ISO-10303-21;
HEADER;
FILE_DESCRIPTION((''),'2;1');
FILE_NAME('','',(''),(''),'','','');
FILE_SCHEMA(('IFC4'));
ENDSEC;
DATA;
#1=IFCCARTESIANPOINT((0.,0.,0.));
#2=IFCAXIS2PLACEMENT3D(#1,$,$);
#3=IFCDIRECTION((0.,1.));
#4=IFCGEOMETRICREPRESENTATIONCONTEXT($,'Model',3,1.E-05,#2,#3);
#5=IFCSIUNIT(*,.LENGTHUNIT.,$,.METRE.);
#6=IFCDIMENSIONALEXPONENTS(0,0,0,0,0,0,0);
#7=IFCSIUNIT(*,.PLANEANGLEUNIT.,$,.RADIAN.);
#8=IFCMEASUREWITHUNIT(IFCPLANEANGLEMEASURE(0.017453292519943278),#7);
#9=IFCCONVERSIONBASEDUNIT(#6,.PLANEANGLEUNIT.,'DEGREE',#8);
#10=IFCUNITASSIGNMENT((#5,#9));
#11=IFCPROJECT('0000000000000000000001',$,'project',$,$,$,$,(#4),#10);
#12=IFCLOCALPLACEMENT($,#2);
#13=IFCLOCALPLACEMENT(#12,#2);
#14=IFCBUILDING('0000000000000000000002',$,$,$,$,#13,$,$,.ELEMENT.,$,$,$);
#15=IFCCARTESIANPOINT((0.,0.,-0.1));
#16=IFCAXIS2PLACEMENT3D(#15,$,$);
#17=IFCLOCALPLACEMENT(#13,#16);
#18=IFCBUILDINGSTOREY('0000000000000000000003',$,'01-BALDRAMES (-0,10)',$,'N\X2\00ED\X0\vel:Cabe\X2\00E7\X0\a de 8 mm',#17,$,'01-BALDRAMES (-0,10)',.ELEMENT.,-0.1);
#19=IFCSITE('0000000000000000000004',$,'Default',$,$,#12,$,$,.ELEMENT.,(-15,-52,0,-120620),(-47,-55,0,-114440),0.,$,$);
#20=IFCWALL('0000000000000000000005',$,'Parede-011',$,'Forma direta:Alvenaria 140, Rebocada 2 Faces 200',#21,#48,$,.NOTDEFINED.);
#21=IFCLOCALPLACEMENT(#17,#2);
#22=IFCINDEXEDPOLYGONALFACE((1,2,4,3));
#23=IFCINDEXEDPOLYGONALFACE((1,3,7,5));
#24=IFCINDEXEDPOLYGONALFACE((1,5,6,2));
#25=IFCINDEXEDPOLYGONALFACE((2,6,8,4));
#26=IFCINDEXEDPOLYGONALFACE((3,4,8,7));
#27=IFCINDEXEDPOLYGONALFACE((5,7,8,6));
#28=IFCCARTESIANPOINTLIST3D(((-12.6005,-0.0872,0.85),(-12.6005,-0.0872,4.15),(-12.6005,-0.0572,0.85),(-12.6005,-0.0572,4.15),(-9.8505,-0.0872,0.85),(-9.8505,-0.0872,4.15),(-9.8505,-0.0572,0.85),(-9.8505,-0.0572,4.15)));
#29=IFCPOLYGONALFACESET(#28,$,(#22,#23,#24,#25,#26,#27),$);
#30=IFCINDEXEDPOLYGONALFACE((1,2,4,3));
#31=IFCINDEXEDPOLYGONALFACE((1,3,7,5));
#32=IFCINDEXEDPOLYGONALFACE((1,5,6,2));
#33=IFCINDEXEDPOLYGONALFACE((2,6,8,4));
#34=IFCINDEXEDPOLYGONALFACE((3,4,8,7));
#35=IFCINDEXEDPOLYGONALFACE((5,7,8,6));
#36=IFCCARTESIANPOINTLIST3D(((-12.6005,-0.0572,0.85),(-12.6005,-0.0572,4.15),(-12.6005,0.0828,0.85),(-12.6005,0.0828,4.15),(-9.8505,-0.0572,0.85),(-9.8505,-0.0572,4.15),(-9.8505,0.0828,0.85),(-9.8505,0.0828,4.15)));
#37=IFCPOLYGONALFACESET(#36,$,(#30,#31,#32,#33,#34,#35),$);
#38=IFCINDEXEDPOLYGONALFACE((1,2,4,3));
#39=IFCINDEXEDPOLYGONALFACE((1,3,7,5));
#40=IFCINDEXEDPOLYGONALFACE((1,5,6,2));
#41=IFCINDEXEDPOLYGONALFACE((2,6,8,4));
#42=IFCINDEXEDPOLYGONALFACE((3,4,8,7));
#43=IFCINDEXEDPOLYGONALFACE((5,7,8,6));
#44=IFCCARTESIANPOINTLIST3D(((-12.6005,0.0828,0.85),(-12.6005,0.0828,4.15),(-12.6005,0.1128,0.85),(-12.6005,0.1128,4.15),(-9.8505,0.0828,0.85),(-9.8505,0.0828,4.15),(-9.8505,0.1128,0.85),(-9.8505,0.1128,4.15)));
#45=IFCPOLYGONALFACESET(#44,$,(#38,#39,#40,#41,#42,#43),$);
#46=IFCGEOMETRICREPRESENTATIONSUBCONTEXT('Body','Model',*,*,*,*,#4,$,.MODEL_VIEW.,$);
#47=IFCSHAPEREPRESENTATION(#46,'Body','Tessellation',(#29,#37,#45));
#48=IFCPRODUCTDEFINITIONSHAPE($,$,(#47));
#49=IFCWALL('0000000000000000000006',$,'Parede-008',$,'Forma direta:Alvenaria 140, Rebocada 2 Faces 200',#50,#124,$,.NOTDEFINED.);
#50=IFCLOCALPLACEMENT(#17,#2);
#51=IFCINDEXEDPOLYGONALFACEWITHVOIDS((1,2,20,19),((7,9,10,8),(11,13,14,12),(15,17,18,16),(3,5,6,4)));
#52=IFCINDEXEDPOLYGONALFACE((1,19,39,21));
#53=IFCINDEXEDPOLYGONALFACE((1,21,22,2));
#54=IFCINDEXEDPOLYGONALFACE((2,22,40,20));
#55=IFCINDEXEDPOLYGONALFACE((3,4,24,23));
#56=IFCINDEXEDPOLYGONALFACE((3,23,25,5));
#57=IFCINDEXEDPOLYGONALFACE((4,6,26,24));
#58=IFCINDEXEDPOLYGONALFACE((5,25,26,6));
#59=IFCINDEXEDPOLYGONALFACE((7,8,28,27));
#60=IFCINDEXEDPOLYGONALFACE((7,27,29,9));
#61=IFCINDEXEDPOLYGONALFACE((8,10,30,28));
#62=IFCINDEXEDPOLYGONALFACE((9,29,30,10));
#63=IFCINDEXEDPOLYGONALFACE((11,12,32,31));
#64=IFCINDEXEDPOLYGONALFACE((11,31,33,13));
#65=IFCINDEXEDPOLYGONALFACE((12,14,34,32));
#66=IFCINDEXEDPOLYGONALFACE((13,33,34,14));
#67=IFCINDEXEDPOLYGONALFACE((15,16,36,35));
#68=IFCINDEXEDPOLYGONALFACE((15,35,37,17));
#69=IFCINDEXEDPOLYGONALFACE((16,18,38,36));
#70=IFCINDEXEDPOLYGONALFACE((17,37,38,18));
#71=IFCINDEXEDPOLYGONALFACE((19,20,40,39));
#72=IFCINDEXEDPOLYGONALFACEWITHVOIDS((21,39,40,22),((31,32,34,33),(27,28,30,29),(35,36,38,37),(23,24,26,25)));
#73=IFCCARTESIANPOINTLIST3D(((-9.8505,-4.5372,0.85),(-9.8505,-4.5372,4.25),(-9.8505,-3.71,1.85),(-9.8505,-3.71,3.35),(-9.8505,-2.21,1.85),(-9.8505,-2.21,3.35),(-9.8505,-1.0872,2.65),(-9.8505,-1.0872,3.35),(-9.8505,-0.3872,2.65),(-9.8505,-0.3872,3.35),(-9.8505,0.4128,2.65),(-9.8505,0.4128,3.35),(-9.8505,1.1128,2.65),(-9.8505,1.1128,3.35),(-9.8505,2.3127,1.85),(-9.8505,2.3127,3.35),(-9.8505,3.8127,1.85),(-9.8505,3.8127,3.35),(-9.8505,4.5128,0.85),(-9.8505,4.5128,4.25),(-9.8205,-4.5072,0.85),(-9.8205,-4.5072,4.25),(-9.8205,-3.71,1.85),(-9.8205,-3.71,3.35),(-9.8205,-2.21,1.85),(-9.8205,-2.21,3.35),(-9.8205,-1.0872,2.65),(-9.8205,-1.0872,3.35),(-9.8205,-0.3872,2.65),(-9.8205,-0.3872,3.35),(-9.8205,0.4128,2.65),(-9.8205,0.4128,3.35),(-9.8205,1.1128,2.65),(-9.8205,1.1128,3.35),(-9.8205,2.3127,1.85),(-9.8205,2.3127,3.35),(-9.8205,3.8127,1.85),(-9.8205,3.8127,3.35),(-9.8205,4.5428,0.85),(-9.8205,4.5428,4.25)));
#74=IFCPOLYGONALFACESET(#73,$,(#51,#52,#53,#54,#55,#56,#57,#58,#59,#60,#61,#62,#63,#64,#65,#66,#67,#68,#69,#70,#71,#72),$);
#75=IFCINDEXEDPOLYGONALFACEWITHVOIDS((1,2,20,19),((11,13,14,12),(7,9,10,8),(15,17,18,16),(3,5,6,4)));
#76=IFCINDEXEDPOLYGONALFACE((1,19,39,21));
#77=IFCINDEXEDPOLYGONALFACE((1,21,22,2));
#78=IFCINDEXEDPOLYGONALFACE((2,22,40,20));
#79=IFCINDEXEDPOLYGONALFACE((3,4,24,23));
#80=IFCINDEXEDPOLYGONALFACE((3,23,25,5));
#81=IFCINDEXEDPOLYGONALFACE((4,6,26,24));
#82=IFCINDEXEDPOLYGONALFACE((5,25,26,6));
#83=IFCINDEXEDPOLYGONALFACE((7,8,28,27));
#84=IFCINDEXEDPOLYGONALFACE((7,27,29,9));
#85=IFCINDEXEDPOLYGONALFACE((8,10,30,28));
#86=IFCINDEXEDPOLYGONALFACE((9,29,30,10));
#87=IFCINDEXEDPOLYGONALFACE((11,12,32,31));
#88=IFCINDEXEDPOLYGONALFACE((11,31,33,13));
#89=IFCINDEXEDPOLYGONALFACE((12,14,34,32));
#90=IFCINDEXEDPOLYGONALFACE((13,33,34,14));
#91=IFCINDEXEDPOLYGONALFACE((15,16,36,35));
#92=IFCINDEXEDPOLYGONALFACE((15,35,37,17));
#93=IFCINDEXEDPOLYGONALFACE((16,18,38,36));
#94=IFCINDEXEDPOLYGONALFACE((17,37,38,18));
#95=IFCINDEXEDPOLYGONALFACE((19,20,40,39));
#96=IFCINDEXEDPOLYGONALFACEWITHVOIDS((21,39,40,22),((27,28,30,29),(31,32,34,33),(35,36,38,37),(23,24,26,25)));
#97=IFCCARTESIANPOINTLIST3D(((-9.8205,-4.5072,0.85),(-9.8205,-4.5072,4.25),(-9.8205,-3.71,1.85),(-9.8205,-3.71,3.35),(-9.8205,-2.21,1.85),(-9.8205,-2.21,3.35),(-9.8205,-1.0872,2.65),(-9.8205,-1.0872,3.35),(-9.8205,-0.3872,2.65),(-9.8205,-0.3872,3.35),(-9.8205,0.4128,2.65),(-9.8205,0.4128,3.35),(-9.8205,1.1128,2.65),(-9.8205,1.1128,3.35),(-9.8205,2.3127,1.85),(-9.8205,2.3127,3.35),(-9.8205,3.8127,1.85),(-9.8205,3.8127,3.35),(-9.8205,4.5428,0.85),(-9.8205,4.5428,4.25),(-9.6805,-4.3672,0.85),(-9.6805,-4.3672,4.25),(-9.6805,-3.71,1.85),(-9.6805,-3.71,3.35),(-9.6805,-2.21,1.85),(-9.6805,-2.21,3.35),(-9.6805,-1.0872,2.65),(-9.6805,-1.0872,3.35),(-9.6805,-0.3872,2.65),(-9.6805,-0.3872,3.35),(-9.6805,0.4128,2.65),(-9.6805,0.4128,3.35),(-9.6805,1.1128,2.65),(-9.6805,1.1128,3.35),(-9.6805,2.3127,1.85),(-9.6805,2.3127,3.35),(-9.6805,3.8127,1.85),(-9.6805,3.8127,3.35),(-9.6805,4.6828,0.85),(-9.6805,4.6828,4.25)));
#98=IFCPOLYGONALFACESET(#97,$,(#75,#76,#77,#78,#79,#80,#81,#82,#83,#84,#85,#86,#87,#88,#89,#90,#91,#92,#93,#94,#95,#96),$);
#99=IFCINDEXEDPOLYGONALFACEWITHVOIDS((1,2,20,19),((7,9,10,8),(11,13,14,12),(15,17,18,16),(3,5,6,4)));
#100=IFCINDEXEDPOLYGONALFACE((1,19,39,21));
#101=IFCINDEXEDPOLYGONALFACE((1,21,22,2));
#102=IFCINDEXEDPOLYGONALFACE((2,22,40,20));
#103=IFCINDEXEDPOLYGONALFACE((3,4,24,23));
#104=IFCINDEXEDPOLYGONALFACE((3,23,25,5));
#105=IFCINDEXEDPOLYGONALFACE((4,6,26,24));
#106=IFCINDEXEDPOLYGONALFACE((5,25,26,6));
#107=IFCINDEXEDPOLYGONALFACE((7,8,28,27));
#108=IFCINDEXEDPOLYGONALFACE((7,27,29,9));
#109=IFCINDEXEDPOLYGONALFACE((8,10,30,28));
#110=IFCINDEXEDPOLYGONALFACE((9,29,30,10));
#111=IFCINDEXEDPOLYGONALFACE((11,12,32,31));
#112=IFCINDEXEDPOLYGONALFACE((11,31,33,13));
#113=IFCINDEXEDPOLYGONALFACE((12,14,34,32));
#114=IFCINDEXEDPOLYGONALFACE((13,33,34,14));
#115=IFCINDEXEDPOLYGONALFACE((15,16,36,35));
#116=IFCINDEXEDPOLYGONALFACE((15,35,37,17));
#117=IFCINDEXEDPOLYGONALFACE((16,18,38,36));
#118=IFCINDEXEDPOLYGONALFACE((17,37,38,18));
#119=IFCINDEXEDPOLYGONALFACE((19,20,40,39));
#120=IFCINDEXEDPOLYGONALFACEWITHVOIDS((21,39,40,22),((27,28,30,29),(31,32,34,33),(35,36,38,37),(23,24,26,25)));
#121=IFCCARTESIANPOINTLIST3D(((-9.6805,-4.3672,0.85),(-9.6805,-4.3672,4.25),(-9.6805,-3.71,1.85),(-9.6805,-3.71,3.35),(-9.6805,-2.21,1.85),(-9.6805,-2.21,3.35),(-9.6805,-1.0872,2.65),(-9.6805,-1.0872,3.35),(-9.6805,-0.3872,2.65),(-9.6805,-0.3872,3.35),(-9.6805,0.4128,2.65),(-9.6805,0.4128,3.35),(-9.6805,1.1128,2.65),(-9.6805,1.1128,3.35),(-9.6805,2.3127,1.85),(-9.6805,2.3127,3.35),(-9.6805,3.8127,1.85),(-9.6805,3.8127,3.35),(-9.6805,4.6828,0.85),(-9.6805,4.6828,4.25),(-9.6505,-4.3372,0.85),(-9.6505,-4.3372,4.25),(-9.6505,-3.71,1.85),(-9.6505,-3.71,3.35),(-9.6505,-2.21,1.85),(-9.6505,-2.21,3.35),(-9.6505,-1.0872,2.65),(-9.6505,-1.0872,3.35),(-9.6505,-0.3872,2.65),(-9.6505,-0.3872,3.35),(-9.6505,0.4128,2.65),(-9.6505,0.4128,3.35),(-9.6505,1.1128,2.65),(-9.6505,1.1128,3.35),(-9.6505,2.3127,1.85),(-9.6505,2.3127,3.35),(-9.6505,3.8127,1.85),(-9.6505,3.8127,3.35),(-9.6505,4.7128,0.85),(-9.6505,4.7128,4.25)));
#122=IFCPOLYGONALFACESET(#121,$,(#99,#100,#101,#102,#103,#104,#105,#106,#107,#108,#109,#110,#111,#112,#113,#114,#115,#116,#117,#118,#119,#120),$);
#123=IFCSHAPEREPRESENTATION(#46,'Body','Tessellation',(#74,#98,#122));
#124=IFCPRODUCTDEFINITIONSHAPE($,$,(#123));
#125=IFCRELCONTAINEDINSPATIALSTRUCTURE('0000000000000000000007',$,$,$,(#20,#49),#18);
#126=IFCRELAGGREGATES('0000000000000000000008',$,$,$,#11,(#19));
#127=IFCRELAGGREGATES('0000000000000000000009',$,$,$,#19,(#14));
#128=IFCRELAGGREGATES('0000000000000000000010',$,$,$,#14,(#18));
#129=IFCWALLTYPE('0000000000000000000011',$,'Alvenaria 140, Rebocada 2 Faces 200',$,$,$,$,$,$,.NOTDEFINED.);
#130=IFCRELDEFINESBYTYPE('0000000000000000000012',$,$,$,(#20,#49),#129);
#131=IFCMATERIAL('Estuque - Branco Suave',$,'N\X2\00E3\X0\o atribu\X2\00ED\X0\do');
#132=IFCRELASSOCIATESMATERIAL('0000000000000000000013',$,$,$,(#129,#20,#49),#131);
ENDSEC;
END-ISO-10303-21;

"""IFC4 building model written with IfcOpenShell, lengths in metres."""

from ifc_helpers import new_model, entity, si_unit, converted_unit, direction, frame, origin, place, context, subcontext, project, spatial, indexed_curve, outline, extrude, material, type_object, element, save


model = new_model("IFC4")

# Units and contexts
model_context = context("Model", 3, precision=1e-05, world=origin(), true_north=direction((0.0, 1.0)))
body_context = subcontext(model_context, "Body", "Model", "MODEL_VIEW")
ifc_project = project(units=[si_unit("LENGTHUNIT", "METRE"), converted_unit("PLANEANGLEUNIT", "DEGREE", entity("IfcPlaneAngleMeasure", 0.017453292519943278), si_unit("PLANEANGLEUNIT", "RADIAN"), dimensions=[0, 0, 0, 0, 0, 0, 0])], contexts=[model_context])

# Site, building, storey
site_placement = place(None, origin())
site = spatial("IfcSite", under=ifc_project, at=site_placement, Name="Default", CompositionType="ELEMENT", RefLatitude=(-15, -52, 0, -120620), RefLongitude=(-47, -55, 0, -114440), RefElevation=0.0)
building_placement = place(site_placement, origin())
building = spatial("IfcBuilding", under=site, at=building_placement, CompositionType="ELEMENT")
storey_placement = place(building_placement, frame((0.0, 0.0, -0.1)))
storey = spatial("IfcBuildingStorey", under=building, at=storey_placement, Name="01-BALDRAMES (-0,10)", ObjectType="Nível:Cabeça de 8 mm", LongName="01-BALDRAMES (-0,10)", CompositionType="ELEMENT", Elevation=-0.1)

# Wall
ifc_material_1 = material(Name="Estuque - Branco Suave", Category="Não atribuído")
wall_type_1 = type_object("IfcWallType", Name="Alvenaria 140, Rebocada 2 Faces 200", PredefinedType="NOTDEFINED", material=ifc_material_1)
wall_1_placement = place(storey_placement, frame((-12.8005, -0.0872, 0.85)))
element("IfcWall", 1, at=wall_1_placement, inside=storey, type_object=wall_type_1, material=ifc_material_1, Name="Parede-011", ObjectType="Forma direta:Alvenaria 140, Rebocada 2 Faces 200", PredefinedType="NOTDEFINED", context=body_context, shape_type="SweptSolid", body=[
    extrude(outline(indexed_curve([(-0.015, -1.375), (0.015, -1.375), (0.015, 1.375), (-0.015, 1.375), (-0.015, -1.375)], self_intersect=False)), frame((1.575, 0.015, 0.0), z_axis=(0.0, 0.0, 1.0), x_axis=(-0.000011, -1.0, 0.0)), (0.0, 0.0, 1.0), 3.3),
    extrude(outline(indexed_curve([(-0.07, -1.375), (0.07, -1.375), (0.07, 1.375), (-0.07, 1.375), (-0.07, -1.375)], self_intersect=False)), frame((1.575, 0.1, 0.0), z_axis=(0.0, 0.0, 1.0), x_axis=(-0.000007, 1.0, 0.0)), (0.0, 0.0, 1.0), 3.3),
    extrude(outline(indexed_curve([(-0.015, -1.375), (0.015, -1.375), (0.015, 1.375), (-0.015, 1.375), (-0.015, -1.375)], self_intersect=False)), frame((1.575, 0.185, 0.0), z_axis=(0.0, 0.0, 1.0), x_axis=(-0.000007, 1.0, 0.0)), (0.0, 0.0, 1.0), 3.3),
])

# Wall, openings
wall_2_placement = place(storey_placement, frame((-9.8505, -4.5372, 0.85), z_axis=(0.0, 0.0, 1.0), x_axis=(0.0, 1.0, 0.0)))
wall_2 = element("IfcWall", 2, at=wall_2_placement, inside=storey, type_object=wall_type_1, material=ifc_material_1, Name="Parede-008", ObjectType="Forma direta:Alvenaria 140, Rebocada 2 Faces 200", PredefinedType="NOTDEFINED", context=body_context, shape_type="SweptSolid", body=[
    extrude(outline(indexed_curve([(-3.2209, -3.1997), (-3.1784, -3.1997), (3.2209, 3.1997), (3.1784, 3.1997), (-3.2209, -3.1997)], self_intersect=False)), frame((4.54, -0.015, 0.0), z_axis=(0.0, 0.0, 1.0), x_axis=(-0.707105, 0.707109, 0.0)), (0.0, 0.0, 1.0), 3.4),
    extrude(outline(indexed_curve([(-3.2986, -3.1997), (-3.1007, -3.1997), (3.2986, 3.1997), (3.1007, 3.1997), (-3.2986, -3.1997)], self_intersect=False)), frame((4.625, -0.1, 0.0), z_axis=(0.0, 0.0, 1.0), x_axis=(0.707105, -0.707108, 0.0)), (0.0, 0.0, 1.0), 3.4),
    extrude(outline(indexed_curve([(-3.2209, -3.1997), (-3.1784, -3.1997), (3.2209, 3.1997), (3.1784, 3.1997), (-3.2209, -3.1997)], self_intersect=False)), frame((4.71, -0.185, 0.0), z_axis=(0.0, 0.0, 1.0), x_axis=(0.707105, -0.707108, 0.0)), (0.0, 0.0, 1.0), 3.4),
])
opening_1_placement = place(storey_placement, frame((-9.8505, -4.5372, 0.85), z_axis=(0.0, 0.0, 1.0), x_axis=(0.0, 1.0, 0.0)))
element("IfcOpeningElement", 3, at=opening_1_placement, cuts=wall_2, PredefinedType="OPENING", context=body_context, shape_type="SweptSolid", body=[
    extrude(outline(indexed_curve([(-0.75, -0.75), (0.75, -0.75), (0.75, 0.75), (-0.75, 0.75), (-0.75, -0.75)], self_intersect=False)), frame((7.5999, -0.2, 1.75), z_axis=(-0.000007, 1.0, 0.0), x_axis=(0.0, 0.0, 1.0)), (0.0, 0.0, 1.0), 0.03),
])
opening_2_placement = place(storey_placement, frame((-9.8505, -4.5372, 0.85), z_axis=(0.0, 0.0, 1.0), x_axis=(0.0, 1.0, 0.0)))
element("IfcOpeningElement", 4, at=opening_2_placement, cuts=wall_2, PredefinedType="OPENING", context=body_context, shape_type="SweptSolid", body=[
    extrude(outline(indexed_curve([(-0.35, -0.35), (0.35, -0.35), (0.35, 0.35), (-0.35, 0.35), (-0.35, -0.35)], self_intersect=False)), frame((3.8001, -0.2, 2.15), z_axis=(-0.000007, 1.0, 0.0), x_axis=(0.0, 0.0, 1.0)), (0.0, 0.0, 1.0), 0.03),
])
opening_3_placement = place(storey_placement, frame((-9.8505, -4.5372, 0.85), z_axis=(0.0, 0.0, 1.0), x_axis=(0.0, 1.0, 0.0)))
element("IfcOpeningElement", 5, at=opening_3_placement, cuts=wall_2, PredefinedType="OPENING", context=body_context, shape_type="SweptSolid", body=[
    extrude(outline(indexed_curve([(-0.35, -0.35), (0.35, -0.35), (0.35, 0.35), (-0.35, 0.35), (-0.35, -0.35)], self_intersect=False)), frame((5.3001, -0.2, 2.15), z_axis=(-0.000007, 1.0, 0.0), x_axis=(0.0, 0.0, 1.0)), (0.0, 0.0, 1.0), 0.03),
])
opening_4_placement = place(storey_placement, frame((-9.8505, -4.5372, 0.85), z_axis=(0.0, 0.0, 1.0), x_axis=(0.0, 1.0, 0.0)))
element("IfcOpeningElement", 6, at=opening_4_placement, cuts=wall_2, PredefinedType="OPENING", context=body_context, shape_type="SweptSolid", body=[
    extrude(outline(indexed_curve([(-0.75, -0.75), (0.75, -0.75), (0.75, 0.75), (-0.75, 0.75), (-0.75, -0.75)], self_intersect=False)), frame((1.5772, -0.2001, 1.75), z_axis=(-0.000007, 1.0, 0.0), x_axis=(0.0, 0.0, 1.0)), (0.0, 0.0, 1.0), 0.03),
])
opening_5_placement = place(storey_placement, frame((-9.8505, -4.5372, 0.85), z_axis=(0.0, 0.0, 1.0), x_axis=(0.0, 1.0, 0.0)))
element("IfcOpeningElement", 7, at=opening_5_placement, cuts=wall_2, PredefinedType="OPENING", context=body_context, shape_type="SweptSolid", body=[
    extrude(outline(indexed_curve([(-0.75, -0.75), (0.75, -0.75), (0.75, 0.75), (-0.75, 0.75), (-0.75, -0.75)], self_intersect=False)), frame((7.5999, -0.03, 1.75), z_axis=(0.000007, -1.0, 0.0), x_axis=(-1.0, -0.000007, 0.0)), (0.0, 0.0, 1.0), 0.14),
])
opening_6_placement = place(storey_placement, frame((-9.8505, -4.5372, 0.85), z_axis=(0.0, 0.0, 1.0), x_axis=(0.0, 1.0, 0.0)))
element("IfcOpeningElement", 8, at=opening_6_placement, cuts=wall_2, PredefinedType="OPENING", context=body_context, shape_type="SweptSolid", body=[
    extrude(outline(indexed_curve([(-0.35, -0.35), (0.35, -0.35), (0.35, 0.35), (-0.35, 0.35), (-0.35, -0.35)], self_intersect=False)), frame((3.8001, -0.03, 2.15), z_axis=(0.000007, -1.0, 0.0), x_axis=(-1.0, -0.000007, 0.0)), (0.0, 0.0, 1.0), 0.14),
])
opening_7_placement = place(storey_placement, frame((-9.8505, -4.5372, 0.85), z_axis=(0.0, 0.0, 1.0), x_axis=(0.0, 1.0, 0.0)))
element("IfcOpeningElement", 9, at=opening_7_placement, cuts=wall_2, PredefinedType="OPENING", context=body_context, shape_type="SweptSolid", body=[
    extrude(outline(indexed_curve([(-0.35, -0.35), (0.35, -0.35), (0.35, 0.35), (-0.35, 0.35), (-0.35, -0.35)], self_intersect=False)), frame((5.3001, -0.03, 2.15), z_axis=(0.000007, -1.0, 0.0), x_axis=(-1.0, -0.000007, 0.0)), (0.0, 0.0, 1.0), 0.14),
])
opening_8_placement = place(storey_placement, frame((-9.8505, -4.5372, 0.85), z_axis=(0.0, 0.0, 1.0), x_axis=(0.0, 1.0, 0.0)))
element("IfcOpeningElement", 10, at=opening_8_placement, cuts=wall_2, PredefinedType="OPENING", context=body_context, shape_type="SweptSolid", body=[
    extrude(outline(indexed_curve([(-0.75, -0.75), (0.75, -0.75), (0.75, 0.75), (-0.75, 0.75), (-0.75, -0.75)], self_intersect=False)), frame((1.5772, -0.0301, 1.75), z_axis=(0.000007, -1.0, 0.0), x_axis=(-1.0, -0.000007, 0.0)), (0.0, 0.0, 1.0), 0.14),
])
opening_9_placement = place(storey_placement, frame((-9.8505, -4.5372, 0.85), z_axis=(0.0, 0.0, 1.0), x_axis=(0.0, 1.0, 0.0)))
element("IfcOpeningElement", 11, at=opening_9_placement, cuts=wall_2, PredefinedType="OPENING", context=body_context, shape_type="SweptSolid", body=[
    extrude(outline(indexed_curve([(-0.75, -0.75), (0.75, -0.75), (0.75, 0.75), (-0.75, 0.75), (-0.75, -0.75)], self_intersect=False)), frame((7.5999, -0.03, 1.75), z_axis=(-0.000007, 1.0, 0.0), x_axis=(1.0, 0.000007, 0.0)), (0.0, 0.0, 1.0), 0.03),
])
opening_10_placement = place(storey_placement, frame((-9.8505, -4.5372, 0.85), z_axis=(0.0, 0.0, 1.0), x_axis=(0.0, 1.0, 0.0)))
element("IfcOpeningElement", 12, at=opening_10_placement, cuts=wall_2, PredefinedType="OPENING", context=body_context, shape_type="SweptSolid", body=[
    extrude(outline(indexed_curve([(-0.35, -0.35), (0.35, -0.35), (0.35, 0.35), (-0.35, 0.35), (-0.35, -0.35)], self_intersect=False)), frame((3.8001, -0.03, 2.15), z_axis=(-0.000007, 1.0, 0.0), x_axis=(1.0, 0.000007, 0.0)), (0.0, 0.0, 1.0), 0.03),
])
opening_11_placement = place(storey_placement, frame((-9.8505, -4.5372, 0.85), z_axis=(0.0, 0.0, 1.0), x_axis=(0.0, 1.0, 0.0)))
element("IfcOpeningElement", 13, at=opening_11_placement, cuts=wall_2, PredefinedType="OPENING", context=body_context, shape_type="SweptSolid", body=[
    extrude(outline(indexed_curve([(-0.35, -0.35), (0.35, -0.35), (0.35, 0.35), (-0.35, 0.35), (-0.35, -0.35)], self_intersect=False)), frame((5.3001, -0.03, 2.15), z_axis=(-0.000007, 1.0, 0.0), x_axis=(1.0, 0.000007, 0.0)), (0.0, 0.0, 1.0), 0.03),
])
opening_12_placement = place(storey_placement, frame((-9.8505, -4.5372, 0.85), z_axis=(0.0, 0.0, 1.0), x_axis=(0.0, 1.0, 0.0)))
element("IfcOpeningElement", 14, at=opening_12_placement, cuts=wall_2, PredefinedType="OPENING", context=body_context, shape_type="SweptSolid", body=[
    extrude(outline(indexed_curve([(-0.75, -0.75), (0.75, -0.75), (0.75, 0.75), (-0.75, 0.75), (-0.75, -0.75)], self_intersect=False)), frame((1.5772, -0.0301, 1.75), z_axis=(-0.000007, 1.0, 0.0), x_axis=(1.0, 0.000007, 0.0)), (0.0, 0.0, 1.0), 0.03),
])

save(model, "model.ifc")
